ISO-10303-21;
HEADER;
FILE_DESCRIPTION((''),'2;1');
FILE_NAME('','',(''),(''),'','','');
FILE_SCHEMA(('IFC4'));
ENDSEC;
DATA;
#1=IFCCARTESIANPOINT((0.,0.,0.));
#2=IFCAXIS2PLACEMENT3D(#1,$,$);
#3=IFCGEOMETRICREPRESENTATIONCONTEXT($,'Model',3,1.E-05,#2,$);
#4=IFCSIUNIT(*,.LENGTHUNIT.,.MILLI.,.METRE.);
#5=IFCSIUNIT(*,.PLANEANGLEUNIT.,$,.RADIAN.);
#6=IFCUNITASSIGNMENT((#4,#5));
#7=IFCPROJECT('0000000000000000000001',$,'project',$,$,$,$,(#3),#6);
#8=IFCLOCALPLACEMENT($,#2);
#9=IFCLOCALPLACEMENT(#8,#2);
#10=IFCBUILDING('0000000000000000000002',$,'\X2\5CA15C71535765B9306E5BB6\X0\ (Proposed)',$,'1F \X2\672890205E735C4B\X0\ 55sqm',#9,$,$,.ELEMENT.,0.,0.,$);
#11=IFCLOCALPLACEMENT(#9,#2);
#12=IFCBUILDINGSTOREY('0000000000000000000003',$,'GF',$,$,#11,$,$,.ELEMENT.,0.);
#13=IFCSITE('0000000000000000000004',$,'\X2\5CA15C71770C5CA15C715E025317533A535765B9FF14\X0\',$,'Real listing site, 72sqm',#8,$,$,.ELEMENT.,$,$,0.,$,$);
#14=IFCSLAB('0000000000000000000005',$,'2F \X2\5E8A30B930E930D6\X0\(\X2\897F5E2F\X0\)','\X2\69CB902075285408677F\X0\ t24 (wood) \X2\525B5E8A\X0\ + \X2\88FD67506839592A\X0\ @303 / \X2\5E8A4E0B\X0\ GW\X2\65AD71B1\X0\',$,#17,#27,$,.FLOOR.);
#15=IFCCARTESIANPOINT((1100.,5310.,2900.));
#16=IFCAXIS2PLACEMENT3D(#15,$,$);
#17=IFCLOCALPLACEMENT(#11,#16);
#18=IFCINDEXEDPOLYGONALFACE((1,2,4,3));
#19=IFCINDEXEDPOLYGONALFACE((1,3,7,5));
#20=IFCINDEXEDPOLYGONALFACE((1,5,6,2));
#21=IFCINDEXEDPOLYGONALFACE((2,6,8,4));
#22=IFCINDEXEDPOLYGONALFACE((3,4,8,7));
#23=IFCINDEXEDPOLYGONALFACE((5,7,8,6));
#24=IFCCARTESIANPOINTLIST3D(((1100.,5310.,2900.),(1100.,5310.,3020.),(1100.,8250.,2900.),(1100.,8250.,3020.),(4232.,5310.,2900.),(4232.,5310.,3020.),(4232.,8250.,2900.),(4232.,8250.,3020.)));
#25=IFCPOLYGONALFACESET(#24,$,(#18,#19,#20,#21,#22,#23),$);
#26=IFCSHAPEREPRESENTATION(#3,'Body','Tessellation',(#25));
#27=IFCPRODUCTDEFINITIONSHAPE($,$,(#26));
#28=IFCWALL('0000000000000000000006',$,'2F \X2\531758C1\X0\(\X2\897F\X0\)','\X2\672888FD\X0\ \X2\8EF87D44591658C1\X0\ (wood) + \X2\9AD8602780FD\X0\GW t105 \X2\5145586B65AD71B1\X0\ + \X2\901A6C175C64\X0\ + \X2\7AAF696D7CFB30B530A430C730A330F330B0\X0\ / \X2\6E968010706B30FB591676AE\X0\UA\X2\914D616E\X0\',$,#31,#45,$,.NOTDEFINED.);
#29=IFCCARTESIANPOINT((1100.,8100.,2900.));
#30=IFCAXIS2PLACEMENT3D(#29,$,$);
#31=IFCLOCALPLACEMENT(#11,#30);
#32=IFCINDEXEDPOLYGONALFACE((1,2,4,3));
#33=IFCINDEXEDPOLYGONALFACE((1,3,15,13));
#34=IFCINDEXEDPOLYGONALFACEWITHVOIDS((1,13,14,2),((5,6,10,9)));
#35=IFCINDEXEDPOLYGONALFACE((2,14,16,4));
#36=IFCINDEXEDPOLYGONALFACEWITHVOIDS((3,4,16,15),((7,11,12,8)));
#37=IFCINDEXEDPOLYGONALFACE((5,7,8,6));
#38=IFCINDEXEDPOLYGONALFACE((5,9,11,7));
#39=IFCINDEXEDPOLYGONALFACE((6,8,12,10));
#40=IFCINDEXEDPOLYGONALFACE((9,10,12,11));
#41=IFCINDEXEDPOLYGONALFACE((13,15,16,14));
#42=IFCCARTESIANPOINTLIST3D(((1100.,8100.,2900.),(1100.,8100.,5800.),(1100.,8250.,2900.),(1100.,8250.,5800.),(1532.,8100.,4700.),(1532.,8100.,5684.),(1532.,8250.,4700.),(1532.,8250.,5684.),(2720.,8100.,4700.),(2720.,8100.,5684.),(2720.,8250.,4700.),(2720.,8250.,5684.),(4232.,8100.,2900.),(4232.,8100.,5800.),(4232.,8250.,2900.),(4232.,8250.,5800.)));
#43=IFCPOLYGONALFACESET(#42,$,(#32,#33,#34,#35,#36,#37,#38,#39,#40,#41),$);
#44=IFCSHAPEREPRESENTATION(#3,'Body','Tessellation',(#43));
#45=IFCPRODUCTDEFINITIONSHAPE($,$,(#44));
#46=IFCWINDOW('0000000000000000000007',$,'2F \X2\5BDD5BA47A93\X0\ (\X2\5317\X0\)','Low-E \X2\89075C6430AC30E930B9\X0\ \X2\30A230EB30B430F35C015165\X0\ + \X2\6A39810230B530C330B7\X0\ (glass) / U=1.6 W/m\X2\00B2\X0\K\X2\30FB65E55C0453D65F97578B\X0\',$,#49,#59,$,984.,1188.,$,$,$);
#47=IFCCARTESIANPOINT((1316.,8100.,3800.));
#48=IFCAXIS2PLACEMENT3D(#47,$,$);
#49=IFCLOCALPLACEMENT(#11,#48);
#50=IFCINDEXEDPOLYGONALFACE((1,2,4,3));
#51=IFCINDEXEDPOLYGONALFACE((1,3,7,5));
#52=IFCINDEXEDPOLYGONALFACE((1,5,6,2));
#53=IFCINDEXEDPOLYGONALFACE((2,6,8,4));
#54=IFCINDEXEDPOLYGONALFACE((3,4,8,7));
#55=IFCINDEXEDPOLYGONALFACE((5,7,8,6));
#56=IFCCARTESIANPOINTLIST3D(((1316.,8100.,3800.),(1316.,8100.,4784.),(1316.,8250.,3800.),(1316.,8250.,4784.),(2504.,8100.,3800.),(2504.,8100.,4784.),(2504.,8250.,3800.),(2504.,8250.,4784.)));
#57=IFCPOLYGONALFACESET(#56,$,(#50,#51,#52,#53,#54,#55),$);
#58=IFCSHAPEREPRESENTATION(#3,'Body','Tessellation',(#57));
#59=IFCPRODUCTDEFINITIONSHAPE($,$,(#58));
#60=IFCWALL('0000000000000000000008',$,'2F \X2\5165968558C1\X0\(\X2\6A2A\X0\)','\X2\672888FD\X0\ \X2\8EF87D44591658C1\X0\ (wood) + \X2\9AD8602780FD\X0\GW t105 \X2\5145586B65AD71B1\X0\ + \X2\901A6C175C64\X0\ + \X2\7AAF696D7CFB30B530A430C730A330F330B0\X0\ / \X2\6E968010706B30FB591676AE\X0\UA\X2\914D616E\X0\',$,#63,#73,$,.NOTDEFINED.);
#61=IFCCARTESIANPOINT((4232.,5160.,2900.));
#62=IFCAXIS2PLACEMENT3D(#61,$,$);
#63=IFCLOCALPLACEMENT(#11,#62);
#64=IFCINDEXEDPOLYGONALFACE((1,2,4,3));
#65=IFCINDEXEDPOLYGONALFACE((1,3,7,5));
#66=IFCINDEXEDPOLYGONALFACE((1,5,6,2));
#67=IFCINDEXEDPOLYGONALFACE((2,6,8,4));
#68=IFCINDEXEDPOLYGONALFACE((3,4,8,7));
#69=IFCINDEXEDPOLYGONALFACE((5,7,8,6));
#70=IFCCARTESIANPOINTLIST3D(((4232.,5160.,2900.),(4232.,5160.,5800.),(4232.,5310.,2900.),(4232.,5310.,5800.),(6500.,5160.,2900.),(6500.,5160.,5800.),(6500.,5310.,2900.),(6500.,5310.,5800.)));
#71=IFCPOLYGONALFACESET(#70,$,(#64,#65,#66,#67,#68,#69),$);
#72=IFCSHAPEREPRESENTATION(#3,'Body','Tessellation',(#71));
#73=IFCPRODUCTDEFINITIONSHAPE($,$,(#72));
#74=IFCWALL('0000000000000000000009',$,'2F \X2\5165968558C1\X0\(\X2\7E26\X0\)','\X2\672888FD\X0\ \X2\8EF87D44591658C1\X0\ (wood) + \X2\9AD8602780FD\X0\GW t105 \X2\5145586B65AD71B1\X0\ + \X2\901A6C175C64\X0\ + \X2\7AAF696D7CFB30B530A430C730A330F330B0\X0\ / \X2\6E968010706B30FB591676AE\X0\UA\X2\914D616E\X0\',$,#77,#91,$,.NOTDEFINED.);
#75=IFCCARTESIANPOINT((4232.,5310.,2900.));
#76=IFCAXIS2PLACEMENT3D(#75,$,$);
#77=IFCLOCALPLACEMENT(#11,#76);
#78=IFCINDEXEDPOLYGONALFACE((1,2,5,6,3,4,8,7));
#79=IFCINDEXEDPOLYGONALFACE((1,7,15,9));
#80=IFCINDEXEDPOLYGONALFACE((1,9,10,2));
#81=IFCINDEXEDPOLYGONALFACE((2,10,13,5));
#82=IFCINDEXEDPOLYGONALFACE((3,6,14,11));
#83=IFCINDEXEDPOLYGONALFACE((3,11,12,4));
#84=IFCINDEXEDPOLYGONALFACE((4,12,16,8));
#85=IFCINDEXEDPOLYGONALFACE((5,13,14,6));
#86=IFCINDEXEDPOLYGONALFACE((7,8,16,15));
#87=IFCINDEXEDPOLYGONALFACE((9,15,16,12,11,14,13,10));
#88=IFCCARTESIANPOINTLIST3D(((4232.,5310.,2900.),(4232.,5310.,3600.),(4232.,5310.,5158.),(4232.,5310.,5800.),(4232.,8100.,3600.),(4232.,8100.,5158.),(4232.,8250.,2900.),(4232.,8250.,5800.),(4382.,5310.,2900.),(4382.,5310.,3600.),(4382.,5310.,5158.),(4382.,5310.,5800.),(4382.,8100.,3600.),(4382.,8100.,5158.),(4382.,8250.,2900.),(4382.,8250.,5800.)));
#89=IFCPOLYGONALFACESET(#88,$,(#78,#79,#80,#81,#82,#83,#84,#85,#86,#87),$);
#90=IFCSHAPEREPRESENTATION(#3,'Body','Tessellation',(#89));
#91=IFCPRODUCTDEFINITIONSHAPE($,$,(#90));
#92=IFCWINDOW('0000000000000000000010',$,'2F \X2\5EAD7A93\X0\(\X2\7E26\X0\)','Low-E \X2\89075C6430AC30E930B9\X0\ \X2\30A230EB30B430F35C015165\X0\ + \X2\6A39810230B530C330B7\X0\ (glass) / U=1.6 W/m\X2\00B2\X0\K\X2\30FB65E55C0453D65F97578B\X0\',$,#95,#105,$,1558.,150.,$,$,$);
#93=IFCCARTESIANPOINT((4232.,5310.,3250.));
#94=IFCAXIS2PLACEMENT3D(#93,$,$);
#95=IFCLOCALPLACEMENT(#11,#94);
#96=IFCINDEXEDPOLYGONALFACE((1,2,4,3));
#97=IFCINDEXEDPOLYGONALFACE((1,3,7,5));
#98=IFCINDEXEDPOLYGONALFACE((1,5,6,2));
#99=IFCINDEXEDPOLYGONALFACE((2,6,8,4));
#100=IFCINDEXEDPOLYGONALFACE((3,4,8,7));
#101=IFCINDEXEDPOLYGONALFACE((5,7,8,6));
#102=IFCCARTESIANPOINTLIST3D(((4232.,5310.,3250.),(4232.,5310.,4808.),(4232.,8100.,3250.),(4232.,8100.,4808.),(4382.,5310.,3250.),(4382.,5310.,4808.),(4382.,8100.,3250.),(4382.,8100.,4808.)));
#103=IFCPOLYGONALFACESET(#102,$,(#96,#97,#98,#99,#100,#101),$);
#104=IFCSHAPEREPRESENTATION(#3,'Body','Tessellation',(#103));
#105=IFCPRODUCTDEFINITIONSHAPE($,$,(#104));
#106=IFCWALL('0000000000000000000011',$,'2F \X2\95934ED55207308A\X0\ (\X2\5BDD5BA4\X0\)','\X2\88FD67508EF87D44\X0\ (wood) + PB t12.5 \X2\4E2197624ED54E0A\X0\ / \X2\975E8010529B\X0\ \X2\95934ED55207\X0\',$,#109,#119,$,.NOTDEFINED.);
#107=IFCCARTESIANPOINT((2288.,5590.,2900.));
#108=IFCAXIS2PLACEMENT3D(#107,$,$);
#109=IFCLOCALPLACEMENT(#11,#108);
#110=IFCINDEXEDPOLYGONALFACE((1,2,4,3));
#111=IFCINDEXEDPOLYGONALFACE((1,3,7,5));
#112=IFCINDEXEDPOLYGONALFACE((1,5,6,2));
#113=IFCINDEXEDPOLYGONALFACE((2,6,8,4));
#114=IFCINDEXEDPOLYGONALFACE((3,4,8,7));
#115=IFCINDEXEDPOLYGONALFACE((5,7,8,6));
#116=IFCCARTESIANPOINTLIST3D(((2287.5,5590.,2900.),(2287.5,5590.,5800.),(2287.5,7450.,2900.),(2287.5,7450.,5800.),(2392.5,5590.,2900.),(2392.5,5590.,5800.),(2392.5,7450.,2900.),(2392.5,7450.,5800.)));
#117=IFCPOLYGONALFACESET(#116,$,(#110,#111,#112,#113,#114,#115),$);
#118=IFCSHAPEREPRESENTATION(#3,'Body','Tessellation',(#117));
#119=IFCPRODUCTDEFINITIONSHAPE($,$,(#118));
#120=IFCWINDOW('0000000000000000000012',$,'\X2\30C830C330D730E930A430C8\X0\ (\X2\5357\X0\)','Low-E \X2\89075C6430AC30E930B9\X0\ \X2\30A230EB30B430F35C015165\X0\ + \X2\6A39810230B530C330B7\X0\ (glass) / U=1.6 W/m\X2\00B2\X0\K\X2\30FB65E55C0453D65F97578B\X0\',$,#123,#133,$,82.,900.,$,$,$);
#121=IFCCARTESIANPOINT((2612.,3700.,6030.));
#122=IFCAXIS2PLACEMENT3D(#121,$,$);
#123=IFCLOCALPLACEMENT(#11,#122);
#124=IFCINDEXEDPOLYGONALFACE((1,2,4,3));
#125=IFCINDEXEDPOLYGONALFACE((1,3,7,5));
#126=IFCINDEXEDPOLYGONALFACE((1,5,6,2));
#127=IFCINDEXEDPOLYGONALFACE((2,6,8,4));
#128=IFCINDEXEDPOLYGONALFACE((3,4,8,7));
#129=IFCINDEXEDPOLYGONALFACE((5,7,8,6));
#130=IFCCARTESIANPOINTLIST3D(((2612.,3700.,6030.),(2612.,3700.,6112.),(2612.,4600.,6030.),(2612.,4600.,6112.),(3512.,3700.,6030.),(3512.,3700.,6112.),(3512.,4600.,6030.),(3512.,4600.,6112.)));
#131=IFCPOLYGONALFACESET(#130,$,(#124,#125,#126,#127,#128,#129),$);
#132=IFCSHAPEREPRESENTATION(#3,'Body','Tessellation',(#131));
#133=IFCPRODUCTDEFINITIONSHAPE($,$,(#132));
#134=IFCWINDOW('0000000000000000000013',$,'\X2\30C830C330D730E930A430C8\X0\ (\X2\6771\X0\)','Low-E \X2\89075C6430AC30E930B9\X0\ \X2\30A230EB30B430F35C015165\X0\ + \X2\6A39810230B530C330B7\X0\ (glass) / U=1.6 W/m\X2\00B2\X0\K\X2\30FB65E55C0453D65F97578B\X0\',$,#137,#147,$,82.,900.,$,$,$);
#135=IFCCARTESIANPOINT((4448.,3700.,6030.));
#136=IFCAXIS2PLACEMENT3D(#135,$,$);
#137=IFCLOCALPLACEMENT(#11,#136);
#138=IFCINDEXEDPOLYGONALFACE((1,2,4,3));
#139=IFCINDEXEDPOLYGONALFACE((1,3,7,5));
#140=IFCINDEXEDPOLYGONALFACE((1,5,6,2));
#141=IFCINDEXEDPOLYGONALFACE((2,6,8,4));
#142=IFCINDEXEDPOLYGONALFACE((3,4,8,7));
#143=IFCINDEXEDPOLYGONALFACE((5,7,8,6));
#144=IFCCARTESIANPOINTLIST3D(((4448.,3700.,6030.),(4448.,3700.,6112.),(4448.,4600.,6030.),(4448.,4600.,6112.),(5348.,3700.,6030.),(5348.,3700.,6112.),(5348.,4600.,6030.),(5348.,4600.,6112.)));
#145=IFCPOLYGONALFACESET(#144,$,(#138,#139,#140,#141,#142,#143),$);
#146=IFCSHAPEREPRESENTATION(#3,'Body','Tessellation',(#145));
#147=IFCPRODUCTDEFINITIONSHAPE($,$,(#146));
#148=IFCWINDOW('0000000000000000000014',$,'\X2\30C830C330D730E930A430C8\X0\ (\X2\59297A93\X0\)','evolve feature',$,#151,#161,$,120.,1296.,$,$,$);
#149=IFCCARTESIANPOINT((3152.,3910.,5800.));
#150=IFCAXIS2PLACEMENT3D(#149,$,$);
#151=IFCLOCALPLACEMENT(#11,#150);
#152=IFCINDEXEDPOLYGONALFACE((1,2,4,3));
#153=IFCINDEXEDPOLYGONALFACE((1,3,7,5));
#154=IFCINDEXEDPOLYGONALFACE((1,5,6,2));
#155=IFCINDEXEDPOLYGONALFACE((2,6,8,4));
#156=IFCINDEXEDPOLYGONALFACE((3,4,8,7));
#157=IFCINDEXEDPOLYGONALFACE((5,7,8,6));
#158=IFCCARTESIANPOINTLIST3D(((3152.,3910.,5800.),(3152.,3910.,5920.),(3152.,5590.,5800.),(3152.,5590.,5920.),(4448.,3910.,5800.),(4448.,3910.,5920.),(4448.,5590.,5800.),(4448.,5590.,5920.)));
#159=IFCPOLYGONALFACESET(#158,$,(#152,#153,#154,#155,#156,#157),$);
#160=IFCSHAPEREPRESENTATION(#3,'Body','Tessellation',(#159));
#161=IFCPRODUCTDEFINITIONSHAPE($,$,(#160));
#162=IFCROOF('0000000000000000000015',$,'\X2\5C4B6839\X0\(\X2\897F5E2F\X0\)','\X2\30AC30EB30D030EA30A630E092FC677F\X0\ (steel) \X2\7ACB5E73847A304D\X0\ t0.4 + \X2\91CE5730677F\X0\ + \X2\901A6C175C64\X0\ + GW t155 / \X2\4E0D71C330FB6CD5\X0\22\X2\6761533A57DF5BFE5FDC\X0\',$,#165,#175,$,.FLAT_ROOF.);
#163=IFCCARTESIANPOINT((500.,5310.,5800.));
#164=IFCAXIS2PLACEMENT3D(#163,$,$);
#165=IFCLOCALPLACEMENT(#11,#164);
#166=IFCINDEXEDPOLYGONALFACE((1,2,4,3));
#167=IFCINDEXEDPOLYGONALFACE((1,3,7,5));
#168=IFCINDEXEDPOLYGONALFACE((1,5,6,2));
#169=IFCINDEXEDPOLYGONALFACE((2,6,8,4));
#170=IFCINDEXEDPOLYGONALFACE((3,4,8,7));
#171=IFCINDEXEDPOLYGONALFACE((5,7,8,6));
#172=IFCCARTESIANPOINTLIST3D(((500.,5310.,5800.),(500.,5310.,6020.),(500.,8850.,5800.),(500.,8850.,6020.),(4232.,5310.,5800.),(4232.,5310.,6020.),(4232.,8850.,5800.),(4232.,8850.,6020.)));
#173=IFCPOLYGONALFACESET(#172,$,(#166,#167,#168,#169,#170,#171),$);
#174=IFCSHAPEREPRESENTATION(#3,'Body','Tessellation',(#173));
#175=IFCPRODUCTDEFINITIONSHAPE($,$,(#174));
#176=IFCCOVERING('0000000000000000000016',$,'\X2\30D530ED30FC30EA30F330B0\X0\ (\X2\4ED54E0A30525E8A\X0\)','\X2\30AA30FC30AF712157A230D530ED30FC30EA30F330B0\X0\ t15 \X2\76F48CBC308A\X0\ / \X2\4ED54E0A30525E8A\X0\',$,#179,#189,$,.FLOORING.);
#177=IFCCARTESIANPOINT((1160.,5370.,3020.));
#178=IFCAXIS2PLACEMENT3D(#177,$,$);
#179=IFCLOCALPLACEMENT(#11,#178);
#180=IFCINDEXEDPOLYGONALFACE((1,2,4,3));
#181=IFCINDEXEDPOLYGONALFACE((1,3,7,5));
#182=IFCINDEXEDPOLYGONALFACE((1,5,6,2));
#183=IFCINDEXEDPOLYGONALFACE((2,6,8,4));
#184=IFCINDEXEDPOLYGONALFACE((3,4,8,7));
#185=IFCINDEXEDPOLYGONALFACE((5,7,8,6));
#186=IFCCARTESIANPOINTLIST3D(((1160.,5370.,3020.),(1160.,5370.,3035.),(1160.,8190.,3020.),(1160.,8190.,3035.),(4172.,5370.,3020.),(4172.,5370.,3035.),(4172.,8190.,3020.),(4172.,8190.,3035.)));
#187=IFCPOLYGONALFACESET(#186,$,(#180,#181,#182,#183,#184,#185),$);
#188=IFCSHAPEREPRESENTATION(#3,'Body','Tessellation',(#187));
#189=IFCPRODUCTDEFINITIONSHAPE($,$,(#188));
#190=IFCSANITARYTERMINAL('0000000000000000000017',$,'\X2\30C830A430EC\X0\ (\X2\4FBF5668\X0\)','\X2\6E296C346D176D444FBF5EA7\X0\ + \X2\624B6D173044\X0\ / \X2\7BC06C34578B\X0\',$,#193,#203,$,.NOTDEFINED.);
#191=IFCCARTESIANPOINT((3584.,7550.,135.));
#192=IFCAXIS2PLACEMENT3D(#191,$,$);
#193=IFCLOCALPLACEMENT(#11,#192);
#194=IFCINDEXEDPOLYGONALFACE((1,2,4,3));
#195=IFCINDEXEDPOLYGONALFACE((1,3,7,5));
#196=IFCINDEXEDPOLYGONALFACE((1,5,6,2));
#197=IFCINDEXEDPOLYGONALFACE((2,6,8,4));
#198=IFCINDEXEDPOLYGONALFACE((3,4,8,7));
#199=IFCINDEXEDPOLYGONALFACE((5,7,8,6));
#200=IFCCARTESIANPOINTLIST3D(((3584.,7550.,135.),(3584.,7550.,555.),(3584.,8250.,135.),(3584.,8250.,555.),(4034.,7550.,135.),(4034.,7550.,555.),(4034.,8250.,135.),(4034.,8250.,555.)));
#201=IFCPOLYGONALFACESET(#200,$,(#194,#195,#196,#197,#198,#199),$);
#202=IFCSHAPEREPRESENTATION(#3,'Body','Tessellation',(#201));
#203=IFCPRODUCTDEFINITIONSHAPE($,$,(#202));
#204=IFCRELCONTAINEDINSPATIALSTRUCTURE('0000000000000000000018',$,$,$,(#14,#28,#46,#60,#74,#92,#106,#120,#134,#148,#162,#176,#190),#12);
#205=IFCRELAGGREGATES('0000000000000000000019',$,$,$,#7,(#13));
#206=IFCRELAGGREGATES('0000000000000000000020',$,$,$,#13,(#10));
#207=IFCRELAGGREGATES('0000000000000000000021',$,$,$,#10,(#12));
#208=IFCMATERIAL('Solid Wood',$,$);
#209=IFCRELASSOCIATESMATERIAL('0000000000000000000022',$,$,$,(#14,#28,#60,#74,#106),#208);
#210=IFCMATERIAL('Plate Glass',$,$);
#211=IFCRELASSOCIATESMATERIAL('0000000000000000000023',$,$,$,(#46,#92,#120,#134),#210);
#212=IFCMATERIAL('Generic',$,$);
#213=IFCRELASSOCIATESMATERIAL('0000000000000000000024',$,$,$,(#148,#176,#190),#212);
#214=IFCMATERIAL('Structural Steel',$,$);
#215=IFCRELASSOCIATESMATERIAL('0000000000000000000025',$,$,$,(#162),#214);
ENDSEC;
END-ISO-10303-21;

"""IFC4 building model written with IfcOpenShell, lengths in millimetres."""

from ifc_helpers import new_model, si_unit, frame, frame_2d, origin, place, context, project, spatial, rectangle, extrude, material, element, fill, save


model = new_model("IFC4")

# Units and contexts
model_context = context("Model", 3, precision=1e-05, world=origin())
ifc_project = project(units=[si_unit("LENGTHUNIT", "METRE", prefix="MILLI"), si_unit("PLANEANGLEUNIT", "RADIAN")], contexts=[model_context])

# Site, building, storey
site_placement = place(None, origin())
site = spatial("IfcSite", under=ifc_project, at=site_placement, Name="岡山県岡山市北区南方４", ObjectType="Real listing site, 72sqm", CompositionType="ELEMENT", RefElevation=0.0)
building_placement = place(site_placement, origin())
building = spatial("IfcBuilding", under=site, at=building_placement, Name="岡山南方の家 (Proposed)", ObjectType="1F 木造平屋 55sqm", CompositionType="ELEMENT", ElevationOfRefHeight=0.0, ElevationOfTerrain=0.0)
storey_placement = place(building_placement, origin())
storey = spatial("IfcBuildingStorey", under=building, at=storey_placement, Name="GF", CompositionType="ELEMENT", Elevation=0.0)

# Slab
ifc_material_1 = material(Name="Solid Wood")
slab_placement = place(storey_placement, frame((1100.0, 5310.0, 2900.0)))
element("IfcSlab", 1, at=slab_placement, inside=storey, material=ifc_material_1, Name="2F 床スラブ(西帯)", Description="構造用合板 t24 (wood) 剛床 + 製材根太 @303 / 床下 GW断熱", PredefinedType="FLOOR", context=model_context, shape_type="SweptSolid", body=[
    extrude(rectangle(XDim=3132.0, YDim=2940.0, at=frame_2d((1566.0, 1470.0))), frame((1100.0, 5310.0, 2900.0)), (0.0, 0.0, 1.0), 120.0),
])

# Wall, opening, window
wall_1_placement = place(storey_placement, frame((1100.0, 8100.0, 2900.0)))
wall_1 = element("IfcWall", 2, at=wall_1_placement, inside=storey, material=ifc_material_1, Name="2F 北壁(西)", Description="木製 軸組外壁 (wood) + 高性能GW t105 充填断熱 + 通気層 + 窯業系サイディング / 準耐火・外皮UA配慮", PredefinedType="NOTDEFINED", context=model_context, shape_type="SweptSolid", body=[
    extrude(rectangle(XDim=3132.0, YDim=150.0, at=frame_2d((1566.0, 75.0))), frame((1100.0, 8100.0, 2900.0)), (0.0, 0.0, 1.0), 2900.0),
])
opening_1_placement = place(storey_placement, frame((1316.0, 8100.0, 3800.0)))
opening_1 = element("IfcOpeningElement", 3, at=opening_1_placement, cuts=wall_1, PredefinedType="NOTDEFINED", context=model_context, shape_type="SweptSolid", body=[
    extrude(rectangle(XDim=1188.0, YDim=150.0, at=frame_2d((594.0, 75.0))), frame((1316.0, 8100.0, 3800.0)), (0.0, 0.0, 1.0), 984.0),
])
ifc_material_2 = material(Name="Plate Glass")
window_1_placement = place(storey_placement, frame((1316.0, 8100.0, 3800.0)))
window_1 = element("IfcWindow", 4, at=window_1_placement, inside=storey, material=ifc_material_2, Name="2F 寝室窓 (北)", Description="Low-E 複層ガラス アルゴン封入 + 樹脂サッシ (glass) / U=1.6 W/m²K・日射取得型", OverallHeight=984.0, OverallWidth=1188.0, context=model_context, shape_type="SweptSolid", body=[
    extrude(rectangle(XDim=1188.0, YDim=150.0, at=frame_2d((594.0, 75.0))), frame((1316.0, 8100.0, 3800.0)), (0.0, 0.0, 1.0), 984.0),
])
fill(opening_1, window_1)

# Wall
wall_2_placement = place(storey_placement, frame((4232.0, 5160.0, 2900.0)))
element("IfcWall", 5, at=wall_2_placement, inside=storey, material=ifc_material_1, Name="2F 入隅壁(横)", Description="木製 軸組外壁 (wood) + 高性能GW t105 充填断熱 + 通気層 + 窯業系サイディング / 準耐火・外皮UA配慮", PredefinedType="NOTDEFINED", context=model_context, shape_type="SweptSolid", body=[
    extrude(rectangle(XDim=2268.0, YDim=150.0, at=frame_2d((1134.0, 75.0))), frame((4232.0, 5160.0, 2900.0)), (0.0, 0.0, 1.0), 2900.0),
])

# Wall, opening, window
wall_3_placement = place(storey_placement, frame((4232.0, 5310.0, 2900.0)))
wall_3 = element("IfcWall", 6, at=wall_3_placement, inside=storey, material=ifc_material_1, Name="2F 入隅壁(縦)", Description="木製 軸組外壁 (wood) + 高性能GW t105 充填断熱 + 通気層 + 窯業系サイディング / 準耐火・外皮UA配慮", PredefinedType="NOTDEFINED", context=model_context, shape_type="SweptSolid", body=[
    extrude(rectangle(XDim=150.0, YDim=2940.0, at=frame_2d((75.0, 1470.0))), frame((4232.0, 5310.0, 2900.0)), (0.0, 0.0, 1.0), 2900.0),
])
opening_2_placement = place(storey_placement, frame((4232.0, 5310.0, 3250.0)))
opening_2 = element("IfcOpeningElement", 7, at=opening_2_placement, cuts=wall_3, PredefinedType="NOTDEFINED", context=model_context, shape_type="SweptSolid", body=[
    extrude(rectangle(XDim=150.0, YDim=2790.0, at=frame_2d((75.0, 1395.0))), frame((4232.0, 5310.0, 3250.0)), (0.0, 0.0, 1.0), 1558.0),
])
window_2_placement = place(storey_placement, frame((4232.0, 5310.0, 3250.0)))
window_2 = element("IfcWindow", 8, at=window_2_placement, inside=storey, material=ifc_material_2, Name="2F 庭窓(縦)", Description="Low-E 複層ガラス アルゴン封入 + 樹脂サッシ (glass) / U=1.6 W/m²K・日射取得型", OverallHeight=1558.0, OverallWidth=150.0, context=model_context, shape_type="SweptSolid", body=[
    extrude(rectangle(XDim=150.0, YDim=2790.0, at=frame_2d((75.0, 1395.0))), frame((4232.0, 5310.0, 3250.0)), (0.0, 0.0, 1.0), 1558.0),
])
fill(opening_2, window_2)

# Wall
wall_4_placement = place(storey_placement, frame((2288.0, 5590.0, 2900.0)))
element("IfcWall", 9, at=wall_4_placement, inside=storey, material=ifc_material_1, Name="2F 間仕切り (寝室)", Description="製材軸組 (wood) + PB t12.5 両面仕上 / 非耐力 間仕切", PredefinedType="NOTDEFINED", context=model_context, shape_type="SweptSolid", body=[
    extrude(rectangle(XDim=105.0, YDim=1860.0, at=frame_2d((52.0, 930.0))), frame((2288.0, 5590.0, 2900.0)), (0.0, 0.0, 1.0), 2900.0),
])

# Windows
window_3_placement = place(storey_placement, frame((2612.0, 3700.0, 6030.0)))
element("IfcWindow", 10, at=window_3_placement, inside=storey, material=ifc_material_2, Name="トップライト (南)", Description="Low-E 複層ガラス アルゴン封入 + 樹脂サッシ (glass) / U=1.6 W/m²K・日射取得型", OverallHeight=82.0, OverallWidth=900.0, context=model_context, shape_type="SweptSolid", body=[
    extrude(rectangle(XDim=900.0, YDim=900.0, at=frame_2d((450.0, 450.0))), frame((2612.0, 3700.0, 6030.0)), (0.0, 0.0, 1.0), 82.0),
])
window_4_placement = place(storey_placement, frame((4448.0, 3700.0, 6030.0)))
element("IfcWindow", 11, at=window_4_placement, inside=storey, material=ifc_material_2, Name="トップライト (東)", Description="Low-E 複層ガラス アルゴン封入 + 樹脂サッシ (glass) / U=1.6 W/m²K・日射取得型", OverallHeight=82.0, OverallWidth=900.0, context=model_context, shape_type="SweptSolid", body=[
    extrude(rectangle(XDim=900.0, YDim=900.0, at=frame_2d((450.0, 450.0))), frame((4448.0, 3700.0, 6030.0)), (0.0, 0.0, 1.0), 82.0),
])
ifc_material_3 = material(Name="Generic")
window_5_placement = place(storey_placement, frame((3152.0, 3910.0, 5800.0)))
element("IfcWindow", 12, at=window_5_placement, inside=storey, material=ifc_material_3, Name="トップライト (天窓)", Description="evolve feature", OverallHeight=120.0, OverallWidth=1296.0, context=model_context, shape_type="SweptSolid", body=[
    extrude(rectangle(XDim=1296.0, YDim=1680.0, at=frame_2d((648.0, 840.0))), frame((3152.0, 3910.0, 5800.0)), (0.0, 0.0, 1.0), 120.0),
])

# Roof
ifc_material_4 = material(Name="Structural Steel")
for number, where, name in (
    (13, (500.0, 5310.0, 5800.0), "屋根(西帯)"),
):
    element("IfcRoof", number, at=place(storey_placement, frame(where)), inside=storey, material=ifc_material_4, Name=name, Description="ガルバリウム鋼板 (steel) 立平葺き t0.4 + 野地板 + 通気層 + GW t155 / 不燃・法22条区域対応", PredefinedType="FLAT_ROOF", context=model_context, shape_type="SweptSolid", body=[
        extrude(rectangle(XDim=3732.0, YDim=3540.0, at=frame_2d((1866.0, 1770.0))), frame((500.0, 5310.0, 5800.0)), (0.0, 0.0, 1.0), 220.0),
    ])

# Covering
covering_placement = place(storey_placement, frame((1160.0, 5370.0, 3020.0)))
element("IfcCovering", 14, at=covering_placement, inside=storey, material=ifc_material_3, Name="フローリング (仕上げ床)", Description="オーク無垢フローリング t15 直貼り / 仕上げ床", PredefinedType="FLOORING", context=model_context, shape_type="SweptSolid", body=[
    extrude(rectangle(XDim=3012.0, YDim=2820.0, at=frame_2d((1506.0, 1410.0))), frame((1160.0, 5370.0, 3020.0)), (0.0, 0.0, 1.0), 15.0),
])

# Sanitary terminal
sanitary_terminal_placement = place(storey_placement, frame((3584.0, 7550.0, 135.0)))
element("IfcSanitaryTerminal", 15, at=sanitary_terminal_placement, inside=storey, material=ifc_material_3, Name="トイレ (便器)", Description="温水洗浄便座 + 手洗い / 節水型", PredefinedType="NOTDEFINED", context=model_context, shape_type="SweptSolid", body=[
    extrude(rectangle(XDim=450.0, YDim=700.0, at=frame_2d((225.0, 350.0))), frame((3584.0, 7550.0, 135.0)), (0.0, 0.0, 1.0), 420.0),
])

save(model, "model.ifc")
